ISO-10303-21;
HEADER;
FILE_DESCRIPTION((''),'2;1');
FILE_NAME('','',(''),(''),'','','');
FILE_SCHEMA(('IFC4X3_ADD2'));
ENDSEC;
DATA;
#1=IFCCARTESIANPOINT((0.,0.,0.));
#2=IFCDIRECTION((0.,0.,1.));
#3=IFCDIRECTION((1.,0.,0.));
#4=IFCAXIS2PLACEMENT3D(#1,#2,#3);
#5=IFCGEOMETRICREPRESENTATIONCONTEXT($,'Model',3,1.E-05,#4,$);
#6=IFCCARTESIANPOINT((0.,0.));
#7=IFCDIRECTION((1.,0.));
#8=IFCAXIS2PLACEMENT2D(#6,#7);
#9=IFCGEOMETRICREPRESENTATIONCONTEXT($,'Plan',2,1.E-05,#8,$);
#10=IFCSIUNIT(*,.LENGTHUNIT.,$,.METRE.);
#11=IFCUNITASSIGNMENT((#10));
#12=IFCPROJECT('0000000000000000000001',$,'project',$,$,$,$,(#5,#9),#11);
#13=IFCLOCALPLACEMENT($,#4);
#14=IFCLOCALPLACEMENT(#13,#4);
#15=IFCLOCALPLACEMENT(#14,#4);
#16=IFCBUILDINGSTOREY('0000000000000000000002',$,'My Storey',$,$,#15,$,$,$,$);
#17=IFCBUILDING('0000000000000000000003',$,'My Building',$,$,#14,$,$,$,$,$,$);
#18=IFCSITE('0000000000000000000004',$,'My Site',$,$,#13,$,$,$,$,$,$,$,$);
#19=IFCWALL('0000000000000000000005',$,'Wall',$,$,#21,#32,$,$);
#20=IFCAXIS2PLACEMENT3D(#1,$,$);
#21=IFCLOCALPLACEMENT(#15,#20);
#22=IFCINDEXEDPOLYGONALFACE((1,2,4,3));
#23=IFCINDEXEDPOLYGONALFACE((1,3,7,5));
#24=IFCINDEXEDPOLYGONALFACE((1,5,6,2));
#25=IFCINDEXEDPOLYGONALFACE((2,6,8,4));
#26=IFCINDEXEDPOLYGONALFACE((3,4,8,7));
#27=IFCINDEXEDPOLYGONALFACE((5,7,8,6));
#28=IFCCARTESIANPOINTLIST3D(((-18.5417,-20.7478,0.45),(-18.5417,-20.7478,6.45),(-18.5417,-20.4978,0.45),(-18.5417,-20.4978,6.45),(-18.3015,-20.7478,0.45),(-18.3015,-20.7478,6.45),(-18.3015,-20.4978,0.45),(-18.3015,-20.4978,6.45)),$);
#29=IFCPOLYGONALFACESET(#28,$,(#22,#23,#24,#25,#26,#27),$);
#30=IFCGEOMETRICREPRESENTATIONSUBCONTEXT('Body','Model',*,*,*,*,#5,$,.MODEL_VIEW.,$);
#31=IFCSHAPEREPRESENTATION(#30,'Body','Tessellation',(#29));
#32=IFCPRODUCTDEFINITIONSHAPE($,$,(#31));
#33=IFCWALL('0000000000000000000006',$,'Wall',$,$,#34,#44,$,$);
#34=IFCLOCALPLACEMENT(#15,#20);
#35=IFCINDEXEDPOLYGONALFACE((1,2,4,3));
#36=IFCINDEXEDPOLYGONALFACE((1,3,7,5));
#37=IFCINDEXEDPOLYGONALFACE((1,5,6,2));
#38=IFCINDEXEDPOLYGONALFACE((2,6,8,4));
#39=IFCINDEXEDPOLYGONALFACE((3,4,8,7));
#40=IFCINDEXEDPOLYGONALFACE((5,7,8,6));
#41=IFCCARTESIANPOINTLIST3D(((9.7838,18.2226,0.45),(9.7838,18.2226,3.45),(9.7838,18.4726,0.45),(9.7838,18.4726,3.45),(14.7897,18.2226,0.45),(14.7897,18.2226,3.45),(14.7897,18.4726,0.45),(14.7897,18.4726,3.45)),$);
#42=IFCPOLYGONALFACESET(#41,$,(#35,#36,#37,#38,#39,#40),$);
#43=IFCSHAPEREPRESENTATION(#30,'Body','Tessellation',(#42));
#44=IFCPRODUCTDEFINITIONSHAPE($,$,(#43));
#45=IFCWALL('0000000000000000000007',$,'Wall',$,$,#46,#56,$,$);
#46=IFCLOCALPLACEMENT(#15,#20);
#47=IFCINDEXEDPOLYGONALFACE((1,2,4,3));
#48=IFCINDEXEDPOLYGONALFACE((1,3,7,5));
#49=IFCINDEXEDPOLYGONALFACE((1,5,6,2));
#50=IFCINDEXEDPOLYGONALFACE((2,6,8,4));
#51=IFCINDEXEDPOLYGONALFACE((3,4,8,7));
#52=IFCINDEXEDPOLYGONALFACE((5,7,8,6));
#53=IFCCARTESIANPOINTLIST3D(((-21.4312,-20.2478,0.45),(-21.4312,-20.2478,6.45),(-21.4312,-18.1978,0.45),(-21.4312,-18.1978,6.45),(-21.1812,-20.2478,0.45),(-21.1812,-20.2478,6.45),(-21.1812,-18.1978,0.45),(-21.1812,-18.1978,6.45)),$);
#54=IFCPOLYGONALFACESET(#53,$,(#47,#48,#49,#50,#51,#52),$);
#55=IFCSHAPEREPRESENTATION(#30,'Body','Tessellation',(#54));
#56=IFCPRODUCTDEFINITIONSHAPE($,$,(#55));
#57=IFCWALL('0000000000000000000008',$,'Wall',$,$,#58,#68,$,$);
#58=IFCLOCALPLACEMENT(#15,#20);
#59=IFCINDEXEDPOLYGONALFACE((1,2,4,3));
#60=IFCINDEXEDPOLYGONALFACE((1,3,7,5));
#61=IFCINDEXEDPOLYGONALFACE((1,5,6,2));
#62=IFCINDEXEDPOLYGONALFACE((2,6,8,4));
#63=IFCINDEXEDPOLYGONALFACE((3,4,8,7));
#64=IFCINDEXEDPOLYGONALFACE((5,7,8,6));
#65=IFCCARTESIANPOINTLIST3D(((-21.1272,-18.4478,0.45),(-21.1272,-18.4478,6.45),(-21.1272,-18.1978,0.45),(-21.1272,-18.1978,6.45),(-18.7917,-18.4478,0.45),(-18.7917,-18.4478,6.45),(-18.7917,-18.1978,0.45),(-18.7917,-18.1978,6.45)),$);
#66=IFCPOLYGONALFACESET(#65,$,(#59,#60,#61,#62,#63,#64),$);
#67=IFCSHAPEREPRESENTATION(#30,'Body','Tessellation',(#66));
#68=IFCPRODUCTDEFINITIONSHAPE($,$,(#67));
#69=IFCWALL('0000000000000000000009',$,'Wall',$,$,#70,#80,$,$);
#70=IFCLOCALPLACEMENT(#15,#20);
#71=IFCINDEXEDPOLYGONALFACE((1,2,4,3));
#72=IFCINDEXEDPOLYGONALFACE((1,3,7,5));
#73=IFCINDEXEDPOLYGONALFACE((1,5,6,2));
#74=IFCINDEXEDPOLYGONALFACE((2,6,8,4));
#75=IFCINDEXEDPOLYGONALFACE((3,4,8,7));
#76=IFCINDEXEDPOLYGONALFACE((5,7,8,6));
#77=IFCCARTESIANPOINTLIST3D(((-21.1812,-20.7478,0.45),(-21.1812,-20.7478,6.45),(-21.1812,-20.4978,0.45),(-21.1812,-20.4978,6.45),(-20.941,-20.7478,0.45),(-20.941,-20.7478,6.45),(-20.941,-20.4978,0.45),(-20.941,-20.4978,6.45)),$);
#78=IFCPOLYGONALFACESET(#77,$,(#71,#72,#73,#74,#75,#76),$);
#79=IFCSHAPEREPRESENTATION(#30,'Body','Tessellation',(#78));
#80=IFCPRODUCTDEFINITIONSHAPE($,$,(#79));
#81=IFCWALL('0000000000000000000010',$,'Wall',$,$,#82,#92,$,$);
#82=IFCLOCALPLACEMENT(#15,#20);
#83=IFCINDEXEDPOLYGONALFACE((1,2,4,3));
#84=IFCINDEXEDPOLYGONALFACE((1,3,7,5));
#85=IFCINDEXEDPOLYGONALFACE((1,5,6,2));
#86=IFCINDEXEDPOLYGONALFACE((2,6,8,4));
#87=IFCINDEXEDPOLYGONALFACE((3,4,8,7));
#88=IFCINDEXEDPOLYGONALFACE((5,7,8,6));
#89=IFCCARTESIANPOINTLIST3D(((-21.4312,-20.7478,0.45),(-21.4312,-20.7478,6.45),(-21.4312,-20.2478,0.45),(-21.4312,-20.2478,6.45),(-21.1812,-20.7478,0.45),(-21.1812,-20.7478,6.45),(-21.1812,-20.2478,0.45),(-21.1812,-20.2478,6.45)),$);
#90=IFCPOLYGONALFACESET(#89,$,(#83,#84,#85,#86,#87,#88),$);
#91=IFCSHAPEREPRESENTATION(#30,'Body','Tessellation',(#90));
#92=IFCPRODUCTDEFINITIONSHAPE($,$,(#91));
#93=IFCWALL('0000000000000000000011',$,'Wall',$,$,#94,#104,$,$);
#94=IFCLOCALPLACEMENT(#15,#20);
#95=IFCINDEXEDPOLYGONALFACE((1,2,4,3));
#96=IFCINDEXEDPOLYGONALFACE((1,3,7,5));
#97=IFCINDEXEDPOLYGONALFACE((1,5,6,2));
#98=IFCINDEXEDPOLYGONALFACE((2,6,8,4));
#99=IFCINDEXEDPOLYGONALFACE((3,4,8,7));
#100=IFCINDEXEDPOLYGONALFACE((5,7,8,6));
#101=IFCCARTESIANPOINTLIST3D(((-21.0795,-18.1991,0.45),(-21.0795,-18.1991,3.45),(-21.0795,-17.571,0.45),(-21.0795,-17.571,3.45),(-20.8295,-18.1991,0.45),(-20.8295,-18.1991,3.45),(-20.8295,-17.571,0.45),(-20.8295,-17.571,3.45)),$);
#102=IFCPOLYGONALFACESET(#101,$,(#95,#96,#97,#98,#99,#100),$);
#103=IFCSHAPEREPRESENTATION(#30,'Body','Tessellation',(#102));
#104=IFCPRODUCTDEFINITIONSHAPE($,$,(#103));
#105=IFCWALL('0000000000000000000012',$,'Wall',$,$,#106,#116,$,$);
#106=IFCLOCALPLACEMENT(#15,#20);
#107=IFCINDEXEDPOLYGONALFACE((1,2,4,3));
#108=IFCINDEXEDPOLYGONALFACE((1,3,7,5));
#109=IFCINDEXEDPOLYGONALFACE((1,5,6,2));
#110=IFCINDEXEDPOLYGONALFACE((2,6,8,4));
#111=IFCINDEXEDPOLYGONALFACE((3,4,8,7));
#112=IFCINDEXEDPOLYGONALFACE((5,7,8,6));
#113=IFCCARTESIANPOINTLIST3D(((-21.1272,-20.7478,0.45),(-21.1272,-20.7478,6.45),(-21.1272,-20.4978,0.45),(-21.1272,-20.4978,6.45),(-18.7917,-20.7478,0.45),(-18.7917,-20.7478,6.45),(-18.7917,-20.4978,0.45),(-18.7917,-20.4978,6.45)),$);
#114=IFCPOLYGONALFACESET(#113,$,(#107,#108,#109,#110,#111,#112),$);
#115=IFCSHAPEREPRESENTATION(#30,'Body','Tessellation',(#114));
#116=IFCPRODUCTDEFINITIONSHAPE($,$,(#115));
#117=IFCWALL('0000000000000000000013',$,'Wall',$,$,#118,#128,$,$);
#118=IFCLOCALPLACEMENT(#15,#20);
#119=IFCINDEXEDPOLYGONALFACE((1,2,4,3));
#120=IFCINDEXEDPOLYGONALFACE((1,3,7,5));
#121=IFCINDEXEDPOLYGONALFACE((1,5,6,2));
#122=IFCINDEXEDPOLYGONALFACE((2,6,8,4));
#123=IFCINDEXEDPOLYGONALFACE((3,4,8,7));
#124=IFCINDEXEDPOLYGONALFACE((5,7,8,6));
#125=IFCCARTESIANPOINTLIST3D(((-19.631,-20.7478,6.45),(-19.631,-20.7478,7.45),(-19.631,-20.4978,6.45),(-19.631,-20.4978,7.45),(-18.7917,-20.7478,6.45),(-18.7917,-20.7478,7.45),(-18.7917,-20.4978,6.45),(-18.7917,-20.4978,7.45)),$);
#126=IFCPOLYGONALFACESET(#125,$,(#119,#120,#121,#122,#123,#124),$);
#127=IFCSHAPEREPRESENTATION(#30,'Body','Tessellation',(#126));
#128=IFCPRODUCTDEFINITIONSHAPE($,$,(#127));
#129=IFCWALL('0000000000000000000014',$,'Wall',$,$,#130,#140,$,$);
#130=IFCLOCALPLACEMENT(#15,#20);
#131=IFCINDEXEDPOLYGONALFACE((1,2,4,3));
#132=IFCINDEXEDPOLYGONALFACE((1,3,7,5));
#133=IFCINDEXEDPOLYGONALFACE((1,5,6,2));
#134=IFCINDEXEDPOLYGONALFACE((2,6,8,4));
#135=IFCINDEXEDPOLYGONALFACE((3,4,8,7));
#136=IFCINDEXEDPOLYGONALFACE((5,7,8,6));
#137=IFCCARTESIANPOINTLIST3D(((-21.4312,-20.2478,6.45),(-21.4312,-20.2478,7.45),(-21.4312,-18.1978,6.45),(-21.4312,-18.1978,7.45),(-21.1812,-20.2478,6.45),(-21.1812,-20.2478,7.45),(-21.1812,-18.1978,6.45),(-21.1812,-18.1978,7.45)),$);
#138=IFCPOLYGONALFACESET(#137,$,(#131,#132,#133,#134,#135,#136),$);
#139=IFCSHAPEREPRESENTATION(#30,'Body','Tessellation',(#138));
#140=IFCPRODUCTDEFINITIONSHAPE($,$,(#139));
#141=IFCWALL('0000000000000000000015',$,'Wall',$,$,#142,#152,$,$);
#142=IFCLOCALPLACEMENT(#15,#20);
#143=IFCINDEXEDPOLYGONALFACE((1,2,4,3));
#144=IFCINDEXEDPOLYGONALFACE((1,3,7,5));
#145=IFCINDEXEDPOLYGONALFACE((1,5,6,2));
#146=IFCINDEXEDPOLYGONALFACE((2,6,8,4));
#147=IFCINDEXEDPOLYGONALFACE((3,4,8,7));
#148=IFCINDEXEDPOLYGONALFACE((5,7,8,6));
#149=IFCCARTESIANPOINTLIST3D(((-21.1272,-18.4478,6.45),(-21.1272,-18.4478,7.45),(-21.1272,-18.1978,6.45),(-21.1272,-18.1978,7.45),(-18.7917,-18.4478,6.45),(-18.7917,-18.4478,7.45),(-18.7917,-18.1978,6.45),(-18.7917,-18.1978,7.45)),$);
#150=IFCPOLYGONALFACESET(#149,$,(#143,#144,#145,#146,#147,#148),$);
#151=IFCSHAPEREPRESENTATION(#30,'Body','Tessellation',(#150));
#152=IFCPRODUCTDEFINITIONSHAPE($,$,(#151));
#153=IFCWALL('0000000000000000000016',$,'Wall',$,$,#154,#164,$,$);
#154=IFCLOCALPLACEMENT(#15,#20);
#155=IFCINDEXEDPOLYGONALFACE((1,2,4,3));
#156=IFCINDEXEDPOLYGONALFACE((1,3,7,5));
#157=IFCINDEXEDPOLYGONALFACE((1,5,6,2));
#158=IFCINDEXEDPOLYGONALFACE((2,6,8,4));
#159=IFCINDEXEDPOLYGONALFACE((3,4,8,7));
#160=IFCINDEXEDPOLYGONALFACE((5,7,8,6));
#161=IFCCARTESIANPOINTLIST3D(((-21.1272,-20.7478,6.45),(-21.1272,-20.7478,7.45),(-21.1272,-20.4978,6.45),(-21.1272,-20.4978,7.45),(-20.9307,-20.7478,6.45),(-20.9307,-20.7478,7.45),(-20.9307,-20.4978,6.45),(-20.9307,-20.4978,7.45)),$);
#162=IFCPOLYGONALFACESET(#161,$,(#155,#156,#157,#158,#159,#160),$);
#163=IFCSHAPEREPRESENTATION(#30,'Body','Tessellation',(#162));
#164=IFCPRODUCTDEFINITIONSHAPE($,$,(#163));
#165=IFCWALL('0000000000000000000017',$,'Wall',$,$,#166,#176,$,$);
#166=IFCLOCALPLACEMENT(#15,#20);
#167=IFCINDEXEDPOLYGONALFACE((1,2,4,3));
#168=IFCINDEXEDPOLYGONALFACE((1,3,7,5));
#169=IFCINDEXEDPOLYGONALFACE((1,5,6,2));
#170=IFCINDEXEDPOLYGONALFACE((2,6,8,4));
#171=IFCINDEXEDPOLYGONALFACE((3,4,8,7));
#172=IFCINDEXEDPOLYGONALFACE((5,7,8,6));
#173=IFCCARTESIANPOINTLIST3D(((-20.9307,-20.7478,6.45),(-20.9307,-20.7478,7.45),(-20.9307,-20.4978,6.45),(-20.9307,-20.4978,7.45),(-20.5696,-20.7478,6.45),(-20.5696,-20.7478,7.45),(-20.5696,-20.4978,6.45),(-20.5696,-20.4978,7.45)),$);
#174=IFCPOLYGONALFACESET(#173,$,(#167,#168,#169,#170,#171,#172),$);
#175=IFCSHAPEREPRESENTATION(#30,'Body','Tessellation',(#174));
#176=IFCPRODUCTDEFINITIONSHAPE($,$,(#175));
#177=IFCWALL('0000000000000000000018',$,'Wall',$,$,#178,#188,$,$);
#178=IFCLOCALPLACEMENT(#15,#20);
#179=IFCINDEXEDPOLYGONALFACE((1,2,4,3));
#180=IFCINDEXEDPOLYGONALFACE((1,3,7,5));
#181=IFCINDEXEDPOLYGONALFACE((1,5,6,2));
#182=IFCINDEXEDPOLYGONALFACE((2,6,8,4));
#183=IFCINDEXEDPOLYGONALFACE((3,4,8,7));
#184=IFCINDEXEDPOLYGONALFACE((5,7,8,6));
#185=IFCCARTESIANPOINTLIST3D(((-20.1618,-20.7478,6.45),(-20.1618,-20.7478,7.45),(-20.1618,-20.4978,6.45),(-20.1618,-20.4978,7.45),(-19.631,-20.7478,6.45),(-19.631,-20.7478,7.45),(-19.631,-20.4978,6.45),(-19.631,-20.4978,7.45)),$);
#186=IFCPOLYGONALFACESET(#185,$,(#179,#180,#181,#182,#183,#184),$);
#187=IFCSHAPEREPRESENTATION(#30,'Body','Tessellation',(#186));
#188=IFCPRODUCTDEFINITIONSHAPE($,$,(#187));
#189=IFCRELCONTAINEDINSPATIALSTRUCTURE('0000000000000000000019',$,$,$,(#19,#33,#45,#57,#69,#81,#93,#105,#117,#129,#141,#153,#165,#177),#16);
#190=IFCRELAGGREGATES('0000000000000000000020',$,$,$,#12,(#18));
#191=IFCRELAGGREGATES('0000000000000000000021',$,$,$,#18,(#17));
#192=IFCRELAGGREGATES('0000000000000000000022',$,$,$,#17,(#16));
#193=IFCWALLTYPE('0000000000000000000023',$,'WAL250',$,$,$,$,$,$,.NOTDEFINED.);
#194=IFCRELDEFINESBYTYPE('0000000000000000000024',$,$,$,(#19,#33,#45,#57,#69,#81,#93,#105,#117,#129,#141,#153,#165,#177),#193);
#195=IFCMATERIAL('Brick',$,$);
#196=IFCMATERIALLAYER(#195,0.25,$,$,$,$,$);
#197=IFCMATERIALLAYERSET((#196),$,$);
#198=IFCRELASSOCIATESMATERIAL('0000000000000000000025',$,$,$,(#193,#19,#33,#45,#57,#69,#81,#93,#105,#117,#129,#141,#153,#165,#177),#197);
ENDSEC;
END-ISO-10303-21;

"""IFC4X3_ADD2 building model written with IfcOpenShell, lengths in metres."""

from ifc_helpers import new_model, si_unit, frame, origin_with_axes, origin_2d_with_axis, place, context, subcontext, project, spatial, line, indexed_curve, outline, extrude, material, layer, layer_set, layer_usage, type_object, element, save


model = new_model("IFC4X3_ADD2")

# Units and contexts
model_context = context("Model", 3, precision=1e-05, world=origin_with_axes())
plan_context = context("Plan", 2, precision=1e-05, world=origin_2d_with_axis())
body_context = subcontext(model_context, "Body", "Model", "MODEL_VIEW")
ifc_project = project(units=[si_unit("LENGTHUNIT", "METRE")], contexts=[model_context, plan_context])

# Site, building, storey
site_placement = place(None, origin_with_axes())
site = spatial("IfcSite", under=ifc_project, at=site_placement, Name="My Site")
building_placement = place(site_placement, origin_with_axes())
building = spatial("IfcBuilding", under=site, at=building_placement, Name="My Building")
storey_placement = place(building_placement, origin_with_axes())
storey = spatial("IfcBuildingStorey", under=building, at=storey_placement, Name="My Storey")

# Shared definitions
ifc_material_1 = material(Name="Brick")

# Walls
ifc_layer_1 = layer(ifc_material_1, 0.25)
ifc_layer_set_1 = layer_set([ifc_layer_1])
wall_type = type_object("IfcWallType", Name="WAL250", PredefinedType="NOTDEFINED", material=ifc_layer_set_1)
ifc_layer_usage_1 = layer_usage(ifc_layer_set_1, "AXIS2", "NEGATIVE", 0.0)
wall_1_placement = place(storey_placement, frame((-18.3015, -20.7478, 0.45), z_axis=(0.0, 0.0, 1.0), x_axis=(-1.0, 0.000001, 0.0)))
element("IfcWall", 1, at=wall_1_placement, inside=storey, type_object=wall_type, material=ifc_layer_usage_1, Name="Wall", context=body_context, shape_type="SweptSolid", body=[
    extrude(outline(indexed_curve([(0.0, -0.25), (0.0, 0.0), (0.2402, 0.0), (0.2402, -0.25)], segments=[line(1, 2, 3, 4, 1)])), origin_with_axes(), (0.0, 0.0, 1.0), 6.0),
])
ifc_layer_usage_2 = layer_usage(ifc_layer_set_1, "AXIS2", "POSITIVE", 0.0)
wall_2_placement = place(storey_placement, frame((9.7838, 18.2226, 0.45), z_axis=(0.0, 0.0, 1.0), x_axis=(1.0, 0.000006, 0.0)))
element("IfcWall", 2, at=wall_2_placement, inside=storey, type_object=wall_type, material=ifc_layer_usage_2, Name="Wall", context=body_context, shape_type="SweptSolid", body=[
    extrude(outline(indexed_curve([(0.0, 0.0), (0.0, 0.25), (5.0059, 0.25), (5.0059, 0.0)], segments=[line(1, 2, 3, 4, 1)])), origin_with_axes(), (0.0, 0.0, 1.0), 3.0),
])
ifc_layer_usage_3 = layer_usage(ifc_layer_set_1, "AXIS2", "NEGATIVE", 0.0)
wall_3_placement = place(storey_placement, frame((-21.4312, -20.2478, 0.45), z_axis=(0.0, 0.0, 1.0), x_axis=(0.000001, 1.0, 0.0)))
element("IfcWall", 3, at=wall_3_placement, inside=storey, type_object=wall_type, material=ifc_layer_usage_3, Name="Wall", context=body_context, shape_type="SweptSolid", body=[
    extrude(outline(indexed_curve([(0.0, -0.25), (0.0, 0.0), (2.05, 0.0), (2.05, -0.25)], segments=[line(1, 2, 3, 4, 1)])), origin_with_axes(), (0.0, 0.0, 1.0), 6.0),
])
ifc_layer_usage_4 = layer_usage(ifc_layer_set_1, "AXIS2", "NEGATIVE", 0.0)
wall_4_placement = place(storey_placement, frame((-18.7917, -18.4478, 0.45), z_axis=(0.0, 0.0, 1.0), x_axis=(-1.0, 0.000001, 0.0)))
element("IfcWall", 4, at=wall_4_placement, inside=storey, type_object=wall_type, material=ifc_layer_usage_4, Name="Wall", context=body_context, shape_type="SweptSolid", body=[
    extrude(outline(indexed_curve([(0.0, -0.25), (0.0, 0.0), (2.3355, 0.0), (2.3355, -0.25)], segments=[line(1, 2, 3, 4, 1)])), origin_with_axes(), (0.0, 0.0, 1.0), 6.0),
])
ifc_layer_usage_5 = layer_usage(ifc_layer_set_1, "AXIS2", "NEGATIVE", 0.0)
wall_5_placement = place(storey_placement, frame((-20.941, -20.7478, 0.45), z_axis=(0.0, 0.0, 1.0), x_axis=(-1.0, 0.000001, 0.0)))
element("IfcWall", 5, at=wall_5_placement, inside=storey, type_object=wall_type, material=ifc_layer_usage_5, Name="Wall", context=body_context, shape_type="SweptSolid", body=[
    extrude(outline(indexed_curve([(0.0, -0.25), (0.0, 0.0), (0.2402, 0.0), (0.2402, -0.25)], segments=[line(1, 2, 3, 4, 1)])), origin_with_axes(), (0.0, 0.0, 1.0), 6.0),
])
ifc_layer_usage_6 = layer_usage(ifc_layer_set_1, "AXIS2", "NEGATIVE", 0.0)
wall_6_placement = place(storey_placement, frame((-21.4312, -20.7478, 0.45), z_axis=(0.0, 0.0, 1.0), x_axis=(0.0, 1.0, 0.0)))
element("IfcWall", 6, at=wall_6_placement, inside=storey, type_object=wall_type, material=ifc_layer_usage_6, Name="Wall", context=body_context, shape_type="SweptSolid", body=[
    extrude(outline(indexed_curve([(0.0, -0.25), (0.0, 0.0), (0.5, 0.0), (0.5, -0.25)], segments=[line(1, 2, 3, 4, 1)])), origin_with_axes(), (0.0, 0.0, 1.0), 6.0),
])
ifc_layer_usage_7 = layer_usage(ifc_layer_set_1, "AXIS2", "POSITIVE", 0.0)
wall_7_placement = place(storey_placement, frame((-20.8295, -18.1991, 0.45), z_axis=(0.0, 0.0, 1.0), x_axis=(-0.000006, 1.0, 0.0)))
element("IfcWall", 7, at=wall_7_placement, inside=storey, type_object=wall_type, material=ifc_layer_usage_7, Name="Wall", context=body_context, shape_type="SweptSolid", body=[
    extrude(outline(indexed_curve([(0.0, 0.0), (0.0, 0.25), (0.628, 0.25), (0.628, 0.0)], segments=[line(1, 2, 3, 4, 1)])), origin_with_axes(), (0.0, 0.0, 1.0), 3.0),
])
ifc_layer_usage_8 = layer_usage(ifc_layer_set_1, "AXIS2", "NEGATIVE", 0.0)
wall_8_placement = place(storey_placement, frame((-18.7917, -20.7478, 0.45), z_axis=(0.0, 0.0, 1.0), x_axis=(-1.0, 0.000001, 0.0)))
element("IfcWall", 8, at=wall_8_placement, inside=storey, type_object=wall_type, material=ifc_layer_usage_8, Name="Wall", context=body_context, shape_type="SweptSolid", body=[
    extrude(outline(indexed_curve([(0.0, -0.25), (0.0, 0.0), (2.3355, 0.0), (2.3355, -0.25)], segments=[line(1, 2, 3, 4, 1)])), origin_with_axes(), (0.0, 0.0, 1.0), 6.0),
])
ifc_layer_usage_9 = layer_usage(ifc_layer_set_1, "AXIS2", "NEGATIVE", 0.0)
wall_9_placement = place(storey_placement, frame((-18.7917, -20.7478, 6.45), z_axis=(0.0, 0.0, 1.0), x_axis=(-1.0, 0.000001, 0.0)))
element("IfcWall", 9, at=wall_9_placement, inside=storey, type_object=wall_type, material=ifc_layer_usage_9, Name="Wall", context=body_context, shape_type="SweptSolid", body=[
    extrude(outline(indexed_curve([(0.0, -0.25), (0.0, 0.0), (0.8393, 0.0), (0.8393, -0.25)], segments=[line(1, 2, 3, 4, 1)])), origin_with_axes(), (0.0, 0.0, 1.0), 1.0),
])
ifc_layer_usage_10 = layer_usage(ifc_layer_set_1, "AXIS2", "NEGATIVE", 0.0)
wall_10_placement = place(storey_placement, frame((-21.4312, -20.2478, 6.45), z_axis=(0.0, 0.0, 1.0), x_axis=(0.000001, 1.0, 0.0)))
element("IfcWall", 10, at=wall_10_placement, inside=storey, type_object=wall_type, material=ifc_layer_usage_10, Name="Wall", context=body_context, shape_type="SweptSolid", body=[
    extrude(outline(indexed_curve([(0.0, -0.25), (0.0, 0.0), (2.05, 0.0), (2.05, -0.25)], segments=[line(1, 2, 3, 4, 1)])), origin_with_axes(), (0.0, 0.0, 1.0), 1.0),
])
ifc_layer_usage_11 = layer_usage(ifc_layer_set_1, "AXIS2", "NEGATIVE", 0.0)
wall_11_placement = place(storey_placement, frame((-18.7917, -18.4478, 6.45), z_axis=(0.0, 0.0, 1.0), x_axis=(-1.0, 0.000001, 0.0)))
element("IfcWall", 11, at=wall_11_placement, inside=storey, type_object=wall_type, material=ifc_layer_usage_11, Name="Wall", context=body_context, shape_type="SweptSolid", body=[
    extrude(outline(indexed_curve([(0.0, -0.25), (0.0, 0.0), (2.3355, 0.0), (2.3355, -0.25)], segments=[line(1, 2, 3, 4, 1)])), origin_with_axes(), (0.0, 0.0, 1.0), 1.0),
])
ifc_layer_usage_12 = layer_usage(ifc_layer_set_1, "AXIS2", "NEGATIVE", 0.0)
wall_12_placement = place(storey_placement, frame((-20.9307, -20.7478, 6.45), z_axis=(0.0, 0.0, 1.0), x_axis=(-1.0, 0.000001, 0.0)))
element("IfcWall", 12, at=wall_12_placement, inside=storey, type_object=wall_type, material=ifc_layer_usage_12, Name="Wall", context=body_context, shape_type="SweptSolid", body=[
    extrude(outline(indexed_curve([(0.0, -0.25), (0.0, 0.0), (0.1964, 0.0), (0.1964, -0.25)], segments=[line(1, 2, 3, 4, 1)])), origin_with_axes(), (0.0, 0.0, 1.0), 1.0),
])
ifc_layer_usage_13 = layer_usage(ifc_layer_set_1, "AXIS2", "NEGATIVE", 0.0)
wall_13_placement = place(storey_placement, frame((-20.5696, -20.7478, 6.45), z_axis=(0.0, 0.0, 1.0), x_axis=(-1.0, 0.000001, 0.0)))
element("IfcWall", 13, at=wall_13_placement, inside=storey, type_object=wall_type, material=ifc_layer_usage_13, Name="Wall", context=body_context, shape_type="SweptSolid", body=[
    extrude(outline(indexed_curve([(0.0, -0.25), (0.0, 0.0), (0.3612, 0.0), (0.3612, -0.25)], segments=[line(1, 2, 3, 4, 1)])), origin_with_axes(), (0.0, 0.0, 1.0), 1.0),
])
ifc_layer_usage_14 = layer_usage(ifc_layer_set_1, "AXIS2", "NEGATIVE", 0.0)
wall_14_placement = place(storey_placement, frame((-19.631, -20.7478, 6.45), z_axis=(0.0, 0.0, 1.0), x_axis=(-1.0, 0.000001, 0.0)))
element("IfcWall", 14, at=wall_14_placement, inside=storey, type_object=wall_type, material=ifc_layer_usage_14, Name="Wall", context=body_context, shape_type="SweptSolid", body=[
    extrude(outline(indexed_curve([(0.0, -0.25), (0.0, 0.0), (0.5308, 0.0), (0.5308, -0.25)], segments=[line(1, 2, 3, 4, 1)])), origin_with_axes(), (0.0, 0.0, 1.0), 1.0),
])

save(model, "model.ifc")
